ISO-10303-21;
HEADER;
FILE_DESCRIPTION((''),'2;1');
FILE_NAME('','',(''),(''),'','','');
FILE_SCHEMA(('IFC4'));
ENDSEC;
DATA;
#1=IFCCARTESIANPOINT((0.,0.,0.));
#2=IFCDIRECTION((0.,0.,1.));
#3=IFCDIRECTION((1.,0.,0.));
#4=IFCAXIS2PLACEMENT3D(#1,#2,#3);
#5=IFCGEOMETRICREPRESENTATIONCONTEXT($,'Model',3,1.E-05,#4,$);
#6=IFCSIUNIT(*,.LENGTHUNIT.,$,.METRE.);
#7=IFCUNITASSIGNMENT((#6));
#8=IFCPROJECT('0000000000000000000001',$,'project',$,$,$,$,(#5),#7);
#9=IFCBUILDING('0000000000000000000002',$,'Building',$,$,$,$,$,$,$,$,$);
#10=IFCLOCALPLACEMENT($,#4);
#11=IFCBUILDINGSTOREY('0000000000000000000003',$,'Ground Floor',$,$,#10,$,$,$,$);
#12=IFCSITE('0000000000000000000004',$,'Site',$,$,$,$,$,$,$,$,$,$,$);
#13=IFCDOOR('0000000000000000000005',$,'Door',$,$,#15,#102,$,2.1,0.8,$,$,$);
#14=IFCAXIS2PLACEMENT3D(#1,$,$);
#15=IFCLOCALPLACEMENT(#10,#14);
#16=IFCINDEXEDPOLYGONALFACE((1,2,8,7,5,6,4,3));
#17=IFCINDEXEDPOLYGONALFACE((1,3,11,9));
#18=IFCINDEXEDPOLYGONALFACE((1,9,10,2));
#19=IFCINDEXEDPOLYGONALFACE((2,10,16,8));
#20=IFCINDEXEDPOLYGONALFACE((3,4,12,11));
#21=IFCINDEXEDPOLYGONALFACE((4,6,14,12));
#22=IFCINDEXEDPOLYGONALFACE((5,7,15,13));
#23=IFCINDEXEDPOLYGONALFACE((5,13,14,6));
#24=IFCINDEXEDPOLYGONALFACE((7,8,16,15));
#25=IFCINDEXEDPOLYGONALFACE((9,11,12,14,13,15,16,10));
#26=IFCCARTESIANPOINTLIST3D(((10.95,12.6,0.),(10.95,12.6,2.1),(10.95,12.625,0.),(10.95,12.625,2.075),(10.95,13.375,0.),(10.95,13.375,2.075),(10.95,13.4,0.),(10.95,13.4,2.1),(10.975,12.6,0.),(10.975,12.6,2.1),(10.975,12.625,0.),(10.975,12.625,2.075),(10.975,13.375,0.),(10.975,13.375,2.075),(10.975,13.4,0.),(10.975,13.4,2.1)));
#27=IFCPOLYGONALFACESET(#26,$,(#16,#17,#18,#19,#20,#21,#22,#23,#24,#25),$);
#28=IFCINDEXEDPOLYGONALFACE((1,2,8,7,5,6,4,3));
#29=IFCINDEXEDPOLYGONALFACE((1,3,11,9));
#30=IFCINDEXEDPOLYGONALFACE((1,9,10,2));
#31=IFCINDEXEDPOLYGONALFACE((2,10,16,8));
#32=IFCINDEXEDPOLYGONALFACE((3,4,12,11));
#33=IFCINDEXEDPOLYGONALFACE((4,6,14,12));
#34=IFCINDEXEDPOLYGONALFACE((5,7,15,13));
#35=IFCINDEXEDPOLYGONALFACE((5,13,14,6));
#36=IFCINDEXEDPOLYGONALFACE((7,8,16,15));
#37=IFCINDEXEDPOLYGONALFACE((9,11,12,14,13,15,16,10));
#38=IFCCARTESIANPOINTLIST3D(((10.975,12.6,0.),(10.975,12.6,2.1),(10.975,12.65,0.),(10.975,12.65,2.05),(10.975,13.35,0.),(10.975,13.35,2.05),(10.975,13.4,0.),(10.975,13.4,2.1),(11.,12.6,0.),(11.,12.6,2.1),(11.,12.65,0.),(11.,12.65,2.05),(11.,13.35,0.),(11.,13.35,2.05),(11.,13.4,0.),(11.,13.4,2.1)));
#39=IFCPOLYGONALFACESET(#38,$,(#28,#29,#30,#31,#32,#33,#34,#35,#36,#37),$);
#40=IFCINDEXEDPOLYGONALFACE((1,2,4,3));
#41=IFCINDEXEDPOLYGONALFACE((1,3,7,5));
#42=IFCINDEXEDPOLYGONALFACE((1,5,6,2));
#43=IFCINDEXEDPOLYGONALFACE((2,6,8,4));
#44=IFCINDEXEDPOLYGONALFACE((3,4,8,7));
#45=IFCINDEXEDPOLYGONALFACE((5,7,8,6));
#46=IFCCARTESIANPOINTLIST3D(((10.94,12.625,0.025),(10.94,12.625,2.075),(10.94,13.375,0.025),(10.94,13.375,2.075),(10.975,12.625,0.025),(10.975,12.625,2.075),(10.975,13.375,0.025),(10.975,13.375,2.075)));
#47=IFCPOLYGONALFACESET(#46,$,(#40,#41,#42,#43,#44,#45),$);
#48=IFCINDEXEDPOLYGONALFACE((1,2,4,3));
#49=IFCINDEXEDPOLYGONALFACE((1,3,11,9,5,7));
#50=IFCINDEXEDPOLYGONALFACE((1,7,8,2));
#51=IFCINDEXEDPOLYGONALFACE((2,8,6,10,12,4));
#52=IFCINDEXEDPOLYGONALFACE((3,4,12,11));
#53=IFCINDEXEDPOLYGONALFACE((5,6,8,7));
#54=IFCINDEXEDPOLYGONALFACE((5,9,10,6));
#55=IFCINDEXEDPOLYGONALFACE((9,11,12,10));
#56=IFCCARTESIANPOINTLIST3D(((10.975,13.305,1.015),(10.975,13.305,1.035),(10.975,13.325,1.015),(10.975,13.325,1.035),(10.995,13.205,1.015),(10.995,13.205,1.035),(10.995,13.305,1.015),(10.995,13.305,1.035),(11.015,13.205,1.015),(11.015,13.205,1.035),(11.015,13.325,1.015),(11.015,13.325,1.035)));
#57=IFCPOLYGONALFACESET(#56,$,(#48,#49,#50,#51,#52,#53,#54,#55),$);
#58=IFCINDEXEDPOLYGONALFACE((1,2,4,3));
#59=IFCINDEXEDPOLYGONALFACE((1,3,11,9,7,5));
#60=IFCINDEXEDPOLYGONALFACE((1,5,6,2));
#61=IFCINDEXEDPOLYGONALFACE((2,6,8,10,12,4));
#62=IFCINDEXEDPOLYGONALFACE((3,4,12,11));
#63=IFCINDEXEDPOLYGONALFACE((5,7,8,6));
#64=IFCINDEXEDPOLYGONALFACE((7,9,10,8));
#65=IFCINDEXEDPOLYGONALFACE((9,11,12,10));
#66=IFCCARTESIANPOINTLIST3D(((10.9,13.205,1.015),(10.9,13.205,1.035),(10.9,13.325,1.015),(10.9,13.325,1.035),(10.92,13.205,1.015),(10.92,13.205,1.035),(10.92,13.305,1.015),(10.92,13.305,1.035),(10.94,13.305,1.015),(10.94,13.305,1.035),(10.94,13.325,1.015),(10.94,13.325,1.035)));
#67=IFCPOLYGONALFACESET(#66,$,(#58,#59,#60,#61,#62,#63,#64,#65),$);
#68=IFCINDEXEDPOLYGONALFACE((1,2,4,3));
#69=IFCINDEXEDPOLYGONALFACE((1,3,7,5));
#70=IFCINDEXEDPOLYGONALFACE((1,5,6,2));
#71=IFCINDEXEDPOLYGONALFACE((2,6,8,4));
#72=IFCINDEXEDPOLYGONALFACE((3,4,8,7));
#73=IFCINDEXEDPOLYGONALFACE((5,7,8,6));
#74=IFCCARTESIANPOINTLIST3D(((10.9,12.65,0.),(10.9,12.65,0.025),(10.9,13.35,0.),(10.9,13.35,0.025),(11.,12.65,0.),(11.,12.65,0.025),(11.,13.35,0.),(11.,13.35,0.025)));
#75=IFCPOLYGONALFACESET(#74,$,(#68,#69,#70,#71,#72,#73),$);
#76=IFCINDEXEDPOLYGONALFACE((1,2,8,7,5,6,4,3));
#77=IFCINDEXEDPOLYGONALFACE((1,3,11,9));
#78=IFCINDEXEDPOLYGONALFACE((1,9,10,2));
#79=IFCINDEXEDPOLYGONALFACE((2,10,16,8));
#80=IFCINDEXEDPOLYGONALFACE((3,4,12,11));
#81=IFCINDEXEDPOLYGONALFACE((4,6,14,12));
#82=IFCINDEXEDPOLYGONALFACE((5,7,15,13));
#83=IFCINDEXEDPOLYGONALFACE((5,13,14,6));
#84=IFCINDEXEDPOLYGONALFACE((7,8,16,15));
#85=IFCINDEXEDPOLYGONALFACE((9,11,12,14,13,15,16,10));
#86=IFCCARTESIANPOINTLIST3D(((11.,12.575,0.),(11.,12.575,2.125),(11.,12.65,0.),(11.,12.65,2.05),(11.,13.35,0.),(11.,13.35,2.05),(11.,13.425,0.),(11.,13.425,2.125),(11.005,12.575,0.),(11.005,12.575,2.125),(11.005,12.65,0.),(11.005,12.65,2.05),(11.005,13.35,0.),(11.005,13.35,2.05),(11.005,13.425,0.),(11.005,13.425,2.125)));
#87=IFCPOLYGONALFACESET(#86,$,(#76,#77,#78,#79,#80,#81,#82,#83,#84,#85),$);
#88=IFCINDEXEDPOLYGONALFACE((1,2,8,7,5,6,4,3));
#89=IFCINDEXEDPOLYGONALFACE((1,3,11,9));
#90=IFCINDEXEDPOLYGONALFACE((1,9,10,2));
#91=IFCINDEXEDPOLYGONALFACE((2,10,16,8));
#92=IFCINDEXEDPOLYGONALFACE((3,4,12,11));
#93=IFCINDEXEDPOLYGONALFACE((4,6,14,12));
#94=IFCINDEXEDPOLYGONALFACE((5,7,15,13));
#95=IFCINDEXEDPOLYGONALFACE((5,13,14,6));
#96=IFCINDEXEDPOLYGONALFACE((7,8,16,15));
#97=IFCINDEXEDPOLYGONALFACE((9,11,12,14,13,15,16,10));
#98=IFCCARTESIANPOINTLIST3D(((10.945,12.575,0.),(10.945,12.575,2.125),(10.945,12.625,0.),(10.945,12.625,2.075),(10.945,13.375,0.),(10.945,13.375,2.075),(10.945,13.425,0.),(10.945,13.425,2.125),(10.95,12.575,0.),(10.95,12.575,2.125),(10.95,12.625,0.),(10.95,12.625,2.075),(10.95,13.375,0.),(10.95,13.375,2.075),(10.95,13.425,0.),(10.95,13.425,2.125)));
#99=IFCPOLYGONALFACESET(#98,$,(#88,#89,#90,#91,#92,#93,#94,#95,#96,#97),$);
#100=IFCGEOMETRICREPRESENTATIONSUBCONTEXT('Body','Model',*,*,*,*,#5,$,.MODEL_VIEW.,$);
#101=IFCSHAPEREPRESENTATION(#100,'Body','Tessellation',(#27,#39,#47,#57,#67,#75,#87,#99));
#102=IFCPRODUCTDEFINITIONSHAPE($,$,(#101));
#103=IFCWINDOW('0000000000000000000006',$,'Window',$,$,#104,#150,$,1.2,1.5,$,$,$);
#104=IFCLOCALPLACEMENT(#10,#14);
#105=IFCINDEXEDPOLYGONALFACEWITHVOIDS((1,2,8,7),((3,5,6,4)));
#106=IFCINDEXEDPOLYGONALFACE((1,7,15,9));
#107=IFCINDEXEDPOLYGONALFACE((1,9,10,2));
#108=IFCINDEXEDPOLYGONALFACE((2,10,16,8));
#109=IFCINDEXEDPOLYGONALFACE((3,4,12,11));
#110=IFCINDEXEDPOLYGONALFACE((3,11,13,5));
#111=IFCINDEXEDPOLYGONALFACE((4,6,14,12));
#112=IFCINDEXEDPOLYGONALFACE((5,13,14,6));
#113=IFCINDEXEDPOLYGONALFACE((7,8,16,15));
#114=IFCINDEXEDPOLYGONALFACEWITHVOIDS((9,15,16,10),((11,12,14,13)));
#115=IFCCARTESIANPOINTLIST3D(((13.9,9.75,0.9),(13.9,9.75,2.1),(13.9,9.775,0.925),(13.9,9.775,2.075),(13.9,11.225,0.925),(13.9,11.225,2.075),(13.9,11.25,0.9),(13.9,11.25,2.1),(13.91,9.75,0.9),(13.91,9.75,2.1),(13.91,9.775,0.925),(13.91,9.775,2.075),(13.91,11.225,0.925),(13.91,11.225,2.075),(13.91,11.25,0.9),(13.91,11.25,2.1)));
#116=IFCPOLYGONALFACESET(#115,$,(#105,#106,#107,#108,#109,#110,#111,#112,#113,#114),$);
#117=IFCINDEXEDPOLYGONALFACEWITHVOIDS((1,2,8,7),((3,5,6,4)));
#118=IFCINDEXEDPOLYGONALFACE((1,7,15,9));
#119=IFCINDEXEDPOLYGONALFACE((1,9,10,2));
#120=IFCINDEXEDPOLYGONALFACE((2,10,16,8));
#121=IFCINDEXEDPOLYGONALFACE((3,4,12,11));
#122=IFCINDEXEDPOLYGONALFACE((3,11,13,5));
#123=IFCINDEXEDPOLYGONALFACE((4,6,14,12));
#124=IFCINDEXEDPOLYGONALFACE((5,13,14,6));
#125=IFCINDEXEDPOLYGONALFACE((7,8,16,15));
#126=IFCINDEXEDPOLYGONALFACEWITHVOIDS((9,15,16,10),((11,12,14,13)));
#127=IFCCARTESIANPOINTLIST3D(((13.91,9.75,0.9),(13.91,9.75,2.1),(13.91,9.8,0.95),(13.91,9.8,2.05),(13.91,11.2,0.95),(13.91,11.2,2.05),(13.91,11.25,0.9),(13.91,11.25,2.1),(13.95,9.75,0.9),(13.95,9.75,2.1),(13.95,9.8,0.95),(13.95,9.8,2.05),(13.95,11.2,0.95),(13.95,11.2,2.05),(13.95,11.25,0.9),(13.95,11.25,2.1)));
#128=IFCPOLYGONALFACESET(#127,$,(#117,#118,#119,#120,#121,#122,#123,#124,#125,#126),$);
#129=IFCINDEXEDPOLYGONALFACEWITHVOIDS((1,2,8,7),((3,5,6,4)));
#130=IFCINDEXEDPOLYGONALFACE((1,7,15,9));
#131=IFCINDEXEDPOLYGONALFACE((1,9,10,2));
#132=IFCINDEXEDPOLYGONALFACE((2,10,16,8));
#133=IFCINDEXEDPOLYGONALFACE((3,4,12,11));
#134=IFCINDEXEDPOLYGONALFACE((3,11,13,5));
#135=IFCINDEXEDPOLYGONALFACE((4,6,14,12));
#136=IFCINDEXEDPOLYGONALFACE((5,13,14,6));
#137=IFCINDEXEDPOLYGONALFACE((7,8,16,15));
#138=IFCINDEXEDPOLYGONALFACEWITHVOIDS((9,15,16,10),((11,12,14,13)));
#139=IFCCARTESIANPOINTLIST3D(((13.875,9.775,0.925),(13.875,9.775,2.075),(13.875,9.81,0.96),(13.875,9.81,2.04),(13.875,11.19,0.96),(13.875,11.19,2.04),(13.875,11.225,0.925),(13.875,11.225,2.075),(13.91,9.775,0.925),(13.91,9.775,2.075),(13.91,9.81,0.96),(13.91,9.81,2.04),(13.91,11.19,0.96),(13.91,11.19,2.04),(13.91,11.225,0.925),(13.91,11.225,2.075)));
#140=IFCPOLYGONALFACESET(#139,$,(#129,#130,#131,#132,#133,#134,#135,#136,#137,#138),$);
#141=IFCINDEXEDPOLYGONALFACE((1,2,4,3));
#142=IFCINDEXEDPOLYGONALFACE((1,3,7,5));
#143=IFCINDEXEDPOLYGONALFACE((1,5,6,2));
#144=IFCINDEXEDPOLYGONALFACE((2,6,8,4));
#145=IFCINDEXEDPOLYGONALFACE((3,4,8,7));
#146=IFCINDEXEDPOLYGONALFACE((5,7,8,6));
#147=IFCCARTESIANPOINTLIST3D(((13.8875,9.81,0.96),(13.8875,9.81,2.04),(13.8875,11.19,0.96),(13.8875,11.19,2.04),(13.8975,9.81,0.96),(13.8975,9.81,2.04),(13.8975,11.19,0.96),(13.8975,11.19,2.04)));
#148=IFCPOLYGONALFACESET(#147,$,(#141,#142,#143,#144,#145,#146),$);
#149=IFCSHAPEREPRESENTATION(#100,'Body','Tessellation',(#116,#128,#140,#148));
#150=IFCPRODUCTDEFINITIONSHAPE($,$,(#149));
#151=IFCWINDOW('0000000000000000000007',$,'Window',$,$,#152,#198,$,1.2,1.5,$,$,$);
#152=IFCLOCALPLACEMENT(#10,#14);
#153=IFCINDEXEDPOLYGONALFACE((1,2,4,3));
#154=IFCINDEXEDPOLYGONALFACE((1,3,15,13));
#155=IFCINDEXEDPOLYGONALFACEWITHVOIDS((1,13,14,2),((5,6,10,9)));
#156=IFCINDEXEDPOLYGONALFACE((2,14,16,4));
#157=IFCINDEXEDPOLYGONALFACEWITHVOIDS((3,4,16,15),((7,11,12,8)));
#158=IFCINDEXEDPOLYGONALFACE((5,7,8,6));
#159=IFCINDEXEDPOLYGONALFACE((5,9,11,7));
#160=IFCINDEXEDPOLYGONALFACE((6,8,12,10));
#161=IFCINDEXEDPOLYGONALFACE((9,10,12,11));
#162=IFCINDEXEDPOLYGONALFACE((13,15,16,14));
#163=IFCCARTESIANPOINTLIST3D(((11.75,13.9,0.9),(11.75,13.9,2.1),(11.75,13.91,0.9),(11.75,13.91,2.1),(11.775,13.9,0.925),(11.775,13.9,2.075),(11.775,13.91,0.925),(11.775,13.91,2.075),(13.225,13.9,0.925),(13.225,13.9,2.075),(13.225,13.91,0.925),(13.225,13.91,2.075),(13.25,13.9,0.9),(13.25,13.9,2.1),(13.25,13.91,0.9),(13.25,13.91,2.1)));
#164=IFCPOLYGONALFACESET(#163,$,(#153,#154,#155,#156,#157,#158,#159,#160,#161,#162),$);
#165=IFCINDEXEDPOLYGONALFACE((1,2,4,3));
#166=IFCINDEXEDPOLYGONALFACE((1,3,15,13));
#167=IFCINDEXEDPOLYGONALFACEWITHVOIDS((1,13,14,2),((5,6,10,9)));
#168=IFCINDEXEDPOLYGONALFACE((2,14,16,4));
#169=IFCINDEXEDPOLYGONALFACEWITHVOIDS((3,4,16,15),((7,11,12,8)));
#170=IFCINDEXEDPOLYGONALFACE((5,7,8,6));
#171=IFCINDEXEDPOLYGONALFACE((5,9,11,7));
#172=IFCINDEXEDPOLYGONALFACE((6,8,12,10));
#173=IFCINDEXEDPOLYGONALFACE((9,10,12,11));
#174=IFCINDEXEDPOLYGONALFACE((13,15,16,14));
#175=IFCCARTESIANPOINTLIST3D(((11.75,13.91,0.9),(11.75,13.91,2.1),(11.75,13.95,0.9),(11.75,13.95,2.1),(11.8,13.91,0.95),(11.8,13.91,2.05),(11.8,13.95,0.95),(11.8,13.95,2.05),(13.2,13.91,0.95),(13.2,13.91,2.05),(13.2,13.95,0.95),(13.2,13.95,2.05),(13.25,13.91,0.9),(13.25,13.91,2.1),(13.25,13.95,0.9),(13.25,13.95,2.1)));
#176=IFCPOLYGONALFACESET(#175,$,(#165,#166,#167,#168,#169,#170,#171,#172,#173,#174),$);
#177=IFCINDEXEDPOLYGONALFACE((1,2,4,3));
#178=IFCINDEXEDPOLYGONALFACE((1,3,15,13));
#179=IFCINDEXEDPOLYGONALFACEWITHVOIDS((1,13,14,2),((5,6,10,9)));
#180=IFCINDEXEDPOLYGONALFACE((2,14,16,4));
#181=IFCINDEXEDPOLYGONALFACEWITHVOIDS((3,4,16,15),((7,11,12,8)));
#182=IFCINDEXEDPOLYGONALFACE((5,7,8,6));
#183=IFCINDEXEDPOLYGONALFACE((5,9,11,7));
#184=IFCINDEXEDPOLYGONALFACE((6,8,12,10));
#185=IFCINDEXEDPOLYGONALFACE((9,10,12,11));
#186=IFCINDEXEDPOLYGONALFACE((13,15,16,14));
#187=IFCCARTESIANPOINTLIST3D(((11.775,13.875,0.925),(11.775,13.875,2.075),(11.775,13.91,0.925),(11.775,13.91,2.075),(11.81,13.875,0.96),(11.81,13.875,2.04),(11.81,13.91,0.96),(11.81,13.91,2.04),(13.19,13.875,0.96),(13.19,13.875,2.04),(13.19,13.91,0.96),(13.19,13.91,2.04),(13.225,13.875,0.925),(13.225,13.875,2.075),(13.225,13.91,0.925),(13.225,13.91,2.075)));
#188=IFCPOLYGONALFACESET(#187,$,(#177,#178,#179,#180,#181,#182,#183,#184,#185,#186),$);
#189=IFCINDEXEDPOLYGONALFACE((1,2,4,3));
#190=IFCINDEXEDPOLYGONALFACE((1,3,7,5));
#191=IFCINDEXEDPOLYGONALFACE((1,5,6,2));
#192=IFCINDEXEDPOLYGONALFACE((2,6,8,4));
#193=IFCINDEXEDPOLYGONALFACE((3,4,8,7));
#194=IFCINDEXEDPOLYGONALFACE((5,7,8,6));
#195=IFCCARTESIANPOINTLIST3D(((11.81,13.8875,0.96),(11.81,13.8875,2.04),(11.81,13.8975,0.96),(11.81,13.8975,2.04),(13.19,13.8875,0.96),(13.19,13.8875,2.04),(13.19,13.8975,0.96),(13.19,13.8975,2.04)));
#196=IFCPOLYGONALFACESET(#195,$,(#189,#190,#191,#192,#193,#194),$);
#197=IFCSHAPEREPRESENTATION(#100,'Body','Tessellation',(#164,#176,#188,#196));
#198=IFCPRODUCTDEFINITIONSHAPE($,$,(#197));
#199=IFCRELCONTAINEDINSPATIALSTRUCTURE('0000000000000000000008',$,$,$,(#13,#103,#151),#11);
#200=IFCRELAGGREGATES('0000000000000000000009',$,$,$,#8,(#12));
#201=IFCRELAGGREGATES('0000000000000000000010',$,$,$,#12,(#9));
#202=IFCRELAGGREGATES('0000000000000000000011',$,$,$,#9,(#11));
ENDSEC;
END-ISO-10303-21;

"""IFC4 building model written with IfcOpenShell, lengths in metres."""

from ifc_helpers import new_model, si_unit, frame, origin_with_axes, place, context, subcontext, project, spatial, line, indexed_curve, outline, extrude, element, save


model = new_model("IFC4")

# Units and contexts
model_context = context("Model", 3, precision=1e-05, world=origin_with_axes())
body_context = subcontext(model_context, "Body", "Model", "MODEL_VIEW")
ifc_project = project(units=[si_unit("LENGTHUNIT", "METRE")], contexts=[model_context])

# Site, building, storey
site = spatial("IfcSite", under=ifc_project, Name="Site")
building = spatial("IfcBuilding", under=site, Name="Building")
storey_placement = place(None, origin_with_axes())
storey = spatial("IfcBuildingStorey", under=building, at=storey_placement, Name="Ground Floor")

# Door
door_1_placement = place(storey_placement, frame((11.0, 12.6, 0.0), z_axis=(0.0, 0.0, 1.0), x_axis=(0.0, 1.0, 0.0)))
element("IfcDoor", 1, at=door_1_placement, inside=storey, Name="Door", OverallHeight=2.1, OverallWidth=0.8, context=body_context, shape_type="SweptSolid", body=[
    extrude(outline(indexed_curve([(0.0, 0.0), (0.0, 2.1), (0.8, 2.1), (0.8, 0.0), (0.775, 0.0), (0.775, 2.075), (0.025, 2.075), (0.025, 0.0)], segments=[line(1, 2, 3, 4, 5, 6, 7, 8, 1)])), frame((0.0, 0.025, 0.0), z_axis=(0.0, -1.0, 0.0), x_axis=(1.0, 0.0, 0.0)), (0.0, 0.0, -1.0), 0.025),
    extrude(outline(indexed_curve([(0.0, 0.0), (0.0, 2.1), (0.8, 2.1), (0.8, 0.0), (0.75, 0.0), (0.75, 2.05), (0.05, 2.05), (0.05, 0.0)], segments=[line(1, 2, 3, 4, 5, 6, 7, 8, 1)])), frame((0.0, 0.0, 0.0), z_axis=(0.0, -1.0, 0.0), x_axis=(1.0, 0.0, 0.0)), (0.0, 0.0, -1.0), 0.025),
    extrude(outline(indexed_curve([(0.0, 0.0), (0.75, 0.0), (0.75, 0.035), (0.0, 0.035)], segments=[line(1, 2, 3, 4, 1)])), frame((0.025, 0.025, 0.025), z_axis=(0.0, 0.0, 1.0), x_axis=(1.0, 0.0, 0.0)), (0.0, 0.0, 1.0), 2.05),
    extrude(outline(indexed_curve([(0.0, 0.0), (0.0, -0.04), (-0.12, -0.04), (-0.12, -0.02), (-0.02, -0.02), (-0.02, 0.0)], segments=[line(1, 2, 3, 4, 5, 6, 1)])), frame((0.725, 0.025, 1.015), z_axis=(0.0, 0.0, 1.0), x_axis=(1.0, 0.0, 0.0)), (0.0, 0.0, 1.0), 0.02),
    extrude(outline(indexed_curve([(0.0, 0.0), (0.0, 0.04), (-0.12, 0.04), (-0.12, 0.02), (-0.02, 0.02), (-0.02, 0.0)], segments=[line(1, 2, 3, 4, 5, 6, 1)])), frame((0.725, 0.06, 1.015), z_axis=(0.0, 0.0, 1.0), x_axis=(1.0, 0.0, 0.0)), (0.0, 0.0, 1.0), 0.02),
    extrude(outline(indexed_curve([(0.0, 0.0), (0.7, 0.0), (0.7, 0.1), (0.0, 0.1)], segments=[line(1, 2, 3, 4, 1)])), frame((0.05, 0.0, 0.0), z_axis=(0.0, 0.0, 1.0), x_axis=(1.0, 0.0, 0.0)), (0.0, 0.0, 1.0), 0.025),
    extrude(outline(indexed_curve([(0.0, 0.0), (0.0, 2.125), (0.85, 2.125), (0.85, 0.0), (0.775, 0.0), (0.775, 2.05), (0.075, 2.05), (0.075, 0.0)], segments=[line(1, 2, 3, 4, 5, 6, 7, 8, 1)])), frame((-0.025, -0.005, 0.0), z_axis=(0.0, -1.0, 0.0), x_axis=(1.0, 0.0, 0.0)), (0.0, 0.0, -1.0), 0.005),
    extrude(outline(indexed_curve([(0.0, 0.0), (0.0, 2.125), (0.85, 2.125), (0.85, 0.0), (0.8, 0.0), (0.8, 2.075), (0.05, 2.075), (0.05, 0.0)], segments=[line(1, 2, 3, 4, 5, 6, 7, 8, 1)])), frame((-0.025, 0.05, 0.0), z_axis=(0.0, -1.0, 0.0), x_axis=(1.0, 0.0, 0.0)), (0.0, 0.0, -1.0), 0.005),
])

# Windows
for number, where, z_axis, x_axis, name in (
    (2, (14.0, 9.75, 0.9), (0.0, 0.0, 1.0), (0.0, 1.0, 0.0), "Window"),
    (3, (13.25, 14.0, 0.9), (0.0, 0.0, 1.0), (-1.0, 0.0, 0.0), "Window"),
):
    element("IfcWindow", number, at=place(storey_placement, frame(where, z_axis=z_axis, x_axis=x_axis)), inside=storey, Name=name, OverallHeight=1.2, OverallWidth=1.5, context=body_context, shape_type="SweptSolid", body=[
        extrude(outline(indexed_curve([(0.0, 0.0), (1.5, 0.0), (1.5, 1.2), (0.0, 1.2)], segments=[line(1, 2, 3, 4, 1)]), holes=[indexed_curve([(0.025, 0.025), (1.475, 0.025), (1.475, 1.175), (0.025, 1.175)], segments=[line(1, 2, 3, 4, 1)])]), frame((0.0, 0.09, 0.0), z_axis=(0.0, -1.0, 0.0), x_axis=(1.0, 0.0, 0.0)), (0.0, 0.0, -1.0), 0.01),
        extrude(outline(indexed_curve([(0.0, 0.0), (1.5, 0.0), (1.5, 1.2), (0.0, 1.2)], segments=[line(1, 2, 3, 4, 1)]), holes=[indexed_curve([(0.05, 0.05), (1.45, 0.05), (1.45, 1.15), (0.05, 1.15)], segments=[line(1, 2, 3, 4, 1)])]), frame((0.0, 0.05, 0.0), z_axis=(0.0, -1.0, 0.0), x_axis=(1.0, 0.0, 0.0)), (0.0, 0.0, -1.0), 0.04),
        extrude(outline(indexed_curve([(0.0, 0.0), (1.45, 0.0), (1.45, 1.15), (0.0, 1.15)], segments=[line(1, 2, 3, 4, 1)]), holes=[indexed_curve([(0.035, 0.035), (1.415, 0.035), (1.415, 1.115), (0.035, 1.115)], segments=[line(1, 2, 3, 4, 1)])]), frame((0.025, 0.09, 0.025), z_axis=(0.0, -1.0, 0.0), x_axis=(1.0, 0.0, 0.0)), (0.0, 0.0, -1.0), 0.035),
        extrude(outline(indexed_curve([(0.035, 0.035), (1.415, 0.035), (1.415, 1.115), (0.035, 1.115)], segments=[line(1, 2, 3, 4, 1)])), frame((0.025, 0.1025, 0.025), z_axis=(0.0, -1.0, 0.0), x_axis=(1.0, 0.0, 0.0)), (0.0, 0.0, -1.0), 0.01),
    ])

save(model, "model.ifc")
